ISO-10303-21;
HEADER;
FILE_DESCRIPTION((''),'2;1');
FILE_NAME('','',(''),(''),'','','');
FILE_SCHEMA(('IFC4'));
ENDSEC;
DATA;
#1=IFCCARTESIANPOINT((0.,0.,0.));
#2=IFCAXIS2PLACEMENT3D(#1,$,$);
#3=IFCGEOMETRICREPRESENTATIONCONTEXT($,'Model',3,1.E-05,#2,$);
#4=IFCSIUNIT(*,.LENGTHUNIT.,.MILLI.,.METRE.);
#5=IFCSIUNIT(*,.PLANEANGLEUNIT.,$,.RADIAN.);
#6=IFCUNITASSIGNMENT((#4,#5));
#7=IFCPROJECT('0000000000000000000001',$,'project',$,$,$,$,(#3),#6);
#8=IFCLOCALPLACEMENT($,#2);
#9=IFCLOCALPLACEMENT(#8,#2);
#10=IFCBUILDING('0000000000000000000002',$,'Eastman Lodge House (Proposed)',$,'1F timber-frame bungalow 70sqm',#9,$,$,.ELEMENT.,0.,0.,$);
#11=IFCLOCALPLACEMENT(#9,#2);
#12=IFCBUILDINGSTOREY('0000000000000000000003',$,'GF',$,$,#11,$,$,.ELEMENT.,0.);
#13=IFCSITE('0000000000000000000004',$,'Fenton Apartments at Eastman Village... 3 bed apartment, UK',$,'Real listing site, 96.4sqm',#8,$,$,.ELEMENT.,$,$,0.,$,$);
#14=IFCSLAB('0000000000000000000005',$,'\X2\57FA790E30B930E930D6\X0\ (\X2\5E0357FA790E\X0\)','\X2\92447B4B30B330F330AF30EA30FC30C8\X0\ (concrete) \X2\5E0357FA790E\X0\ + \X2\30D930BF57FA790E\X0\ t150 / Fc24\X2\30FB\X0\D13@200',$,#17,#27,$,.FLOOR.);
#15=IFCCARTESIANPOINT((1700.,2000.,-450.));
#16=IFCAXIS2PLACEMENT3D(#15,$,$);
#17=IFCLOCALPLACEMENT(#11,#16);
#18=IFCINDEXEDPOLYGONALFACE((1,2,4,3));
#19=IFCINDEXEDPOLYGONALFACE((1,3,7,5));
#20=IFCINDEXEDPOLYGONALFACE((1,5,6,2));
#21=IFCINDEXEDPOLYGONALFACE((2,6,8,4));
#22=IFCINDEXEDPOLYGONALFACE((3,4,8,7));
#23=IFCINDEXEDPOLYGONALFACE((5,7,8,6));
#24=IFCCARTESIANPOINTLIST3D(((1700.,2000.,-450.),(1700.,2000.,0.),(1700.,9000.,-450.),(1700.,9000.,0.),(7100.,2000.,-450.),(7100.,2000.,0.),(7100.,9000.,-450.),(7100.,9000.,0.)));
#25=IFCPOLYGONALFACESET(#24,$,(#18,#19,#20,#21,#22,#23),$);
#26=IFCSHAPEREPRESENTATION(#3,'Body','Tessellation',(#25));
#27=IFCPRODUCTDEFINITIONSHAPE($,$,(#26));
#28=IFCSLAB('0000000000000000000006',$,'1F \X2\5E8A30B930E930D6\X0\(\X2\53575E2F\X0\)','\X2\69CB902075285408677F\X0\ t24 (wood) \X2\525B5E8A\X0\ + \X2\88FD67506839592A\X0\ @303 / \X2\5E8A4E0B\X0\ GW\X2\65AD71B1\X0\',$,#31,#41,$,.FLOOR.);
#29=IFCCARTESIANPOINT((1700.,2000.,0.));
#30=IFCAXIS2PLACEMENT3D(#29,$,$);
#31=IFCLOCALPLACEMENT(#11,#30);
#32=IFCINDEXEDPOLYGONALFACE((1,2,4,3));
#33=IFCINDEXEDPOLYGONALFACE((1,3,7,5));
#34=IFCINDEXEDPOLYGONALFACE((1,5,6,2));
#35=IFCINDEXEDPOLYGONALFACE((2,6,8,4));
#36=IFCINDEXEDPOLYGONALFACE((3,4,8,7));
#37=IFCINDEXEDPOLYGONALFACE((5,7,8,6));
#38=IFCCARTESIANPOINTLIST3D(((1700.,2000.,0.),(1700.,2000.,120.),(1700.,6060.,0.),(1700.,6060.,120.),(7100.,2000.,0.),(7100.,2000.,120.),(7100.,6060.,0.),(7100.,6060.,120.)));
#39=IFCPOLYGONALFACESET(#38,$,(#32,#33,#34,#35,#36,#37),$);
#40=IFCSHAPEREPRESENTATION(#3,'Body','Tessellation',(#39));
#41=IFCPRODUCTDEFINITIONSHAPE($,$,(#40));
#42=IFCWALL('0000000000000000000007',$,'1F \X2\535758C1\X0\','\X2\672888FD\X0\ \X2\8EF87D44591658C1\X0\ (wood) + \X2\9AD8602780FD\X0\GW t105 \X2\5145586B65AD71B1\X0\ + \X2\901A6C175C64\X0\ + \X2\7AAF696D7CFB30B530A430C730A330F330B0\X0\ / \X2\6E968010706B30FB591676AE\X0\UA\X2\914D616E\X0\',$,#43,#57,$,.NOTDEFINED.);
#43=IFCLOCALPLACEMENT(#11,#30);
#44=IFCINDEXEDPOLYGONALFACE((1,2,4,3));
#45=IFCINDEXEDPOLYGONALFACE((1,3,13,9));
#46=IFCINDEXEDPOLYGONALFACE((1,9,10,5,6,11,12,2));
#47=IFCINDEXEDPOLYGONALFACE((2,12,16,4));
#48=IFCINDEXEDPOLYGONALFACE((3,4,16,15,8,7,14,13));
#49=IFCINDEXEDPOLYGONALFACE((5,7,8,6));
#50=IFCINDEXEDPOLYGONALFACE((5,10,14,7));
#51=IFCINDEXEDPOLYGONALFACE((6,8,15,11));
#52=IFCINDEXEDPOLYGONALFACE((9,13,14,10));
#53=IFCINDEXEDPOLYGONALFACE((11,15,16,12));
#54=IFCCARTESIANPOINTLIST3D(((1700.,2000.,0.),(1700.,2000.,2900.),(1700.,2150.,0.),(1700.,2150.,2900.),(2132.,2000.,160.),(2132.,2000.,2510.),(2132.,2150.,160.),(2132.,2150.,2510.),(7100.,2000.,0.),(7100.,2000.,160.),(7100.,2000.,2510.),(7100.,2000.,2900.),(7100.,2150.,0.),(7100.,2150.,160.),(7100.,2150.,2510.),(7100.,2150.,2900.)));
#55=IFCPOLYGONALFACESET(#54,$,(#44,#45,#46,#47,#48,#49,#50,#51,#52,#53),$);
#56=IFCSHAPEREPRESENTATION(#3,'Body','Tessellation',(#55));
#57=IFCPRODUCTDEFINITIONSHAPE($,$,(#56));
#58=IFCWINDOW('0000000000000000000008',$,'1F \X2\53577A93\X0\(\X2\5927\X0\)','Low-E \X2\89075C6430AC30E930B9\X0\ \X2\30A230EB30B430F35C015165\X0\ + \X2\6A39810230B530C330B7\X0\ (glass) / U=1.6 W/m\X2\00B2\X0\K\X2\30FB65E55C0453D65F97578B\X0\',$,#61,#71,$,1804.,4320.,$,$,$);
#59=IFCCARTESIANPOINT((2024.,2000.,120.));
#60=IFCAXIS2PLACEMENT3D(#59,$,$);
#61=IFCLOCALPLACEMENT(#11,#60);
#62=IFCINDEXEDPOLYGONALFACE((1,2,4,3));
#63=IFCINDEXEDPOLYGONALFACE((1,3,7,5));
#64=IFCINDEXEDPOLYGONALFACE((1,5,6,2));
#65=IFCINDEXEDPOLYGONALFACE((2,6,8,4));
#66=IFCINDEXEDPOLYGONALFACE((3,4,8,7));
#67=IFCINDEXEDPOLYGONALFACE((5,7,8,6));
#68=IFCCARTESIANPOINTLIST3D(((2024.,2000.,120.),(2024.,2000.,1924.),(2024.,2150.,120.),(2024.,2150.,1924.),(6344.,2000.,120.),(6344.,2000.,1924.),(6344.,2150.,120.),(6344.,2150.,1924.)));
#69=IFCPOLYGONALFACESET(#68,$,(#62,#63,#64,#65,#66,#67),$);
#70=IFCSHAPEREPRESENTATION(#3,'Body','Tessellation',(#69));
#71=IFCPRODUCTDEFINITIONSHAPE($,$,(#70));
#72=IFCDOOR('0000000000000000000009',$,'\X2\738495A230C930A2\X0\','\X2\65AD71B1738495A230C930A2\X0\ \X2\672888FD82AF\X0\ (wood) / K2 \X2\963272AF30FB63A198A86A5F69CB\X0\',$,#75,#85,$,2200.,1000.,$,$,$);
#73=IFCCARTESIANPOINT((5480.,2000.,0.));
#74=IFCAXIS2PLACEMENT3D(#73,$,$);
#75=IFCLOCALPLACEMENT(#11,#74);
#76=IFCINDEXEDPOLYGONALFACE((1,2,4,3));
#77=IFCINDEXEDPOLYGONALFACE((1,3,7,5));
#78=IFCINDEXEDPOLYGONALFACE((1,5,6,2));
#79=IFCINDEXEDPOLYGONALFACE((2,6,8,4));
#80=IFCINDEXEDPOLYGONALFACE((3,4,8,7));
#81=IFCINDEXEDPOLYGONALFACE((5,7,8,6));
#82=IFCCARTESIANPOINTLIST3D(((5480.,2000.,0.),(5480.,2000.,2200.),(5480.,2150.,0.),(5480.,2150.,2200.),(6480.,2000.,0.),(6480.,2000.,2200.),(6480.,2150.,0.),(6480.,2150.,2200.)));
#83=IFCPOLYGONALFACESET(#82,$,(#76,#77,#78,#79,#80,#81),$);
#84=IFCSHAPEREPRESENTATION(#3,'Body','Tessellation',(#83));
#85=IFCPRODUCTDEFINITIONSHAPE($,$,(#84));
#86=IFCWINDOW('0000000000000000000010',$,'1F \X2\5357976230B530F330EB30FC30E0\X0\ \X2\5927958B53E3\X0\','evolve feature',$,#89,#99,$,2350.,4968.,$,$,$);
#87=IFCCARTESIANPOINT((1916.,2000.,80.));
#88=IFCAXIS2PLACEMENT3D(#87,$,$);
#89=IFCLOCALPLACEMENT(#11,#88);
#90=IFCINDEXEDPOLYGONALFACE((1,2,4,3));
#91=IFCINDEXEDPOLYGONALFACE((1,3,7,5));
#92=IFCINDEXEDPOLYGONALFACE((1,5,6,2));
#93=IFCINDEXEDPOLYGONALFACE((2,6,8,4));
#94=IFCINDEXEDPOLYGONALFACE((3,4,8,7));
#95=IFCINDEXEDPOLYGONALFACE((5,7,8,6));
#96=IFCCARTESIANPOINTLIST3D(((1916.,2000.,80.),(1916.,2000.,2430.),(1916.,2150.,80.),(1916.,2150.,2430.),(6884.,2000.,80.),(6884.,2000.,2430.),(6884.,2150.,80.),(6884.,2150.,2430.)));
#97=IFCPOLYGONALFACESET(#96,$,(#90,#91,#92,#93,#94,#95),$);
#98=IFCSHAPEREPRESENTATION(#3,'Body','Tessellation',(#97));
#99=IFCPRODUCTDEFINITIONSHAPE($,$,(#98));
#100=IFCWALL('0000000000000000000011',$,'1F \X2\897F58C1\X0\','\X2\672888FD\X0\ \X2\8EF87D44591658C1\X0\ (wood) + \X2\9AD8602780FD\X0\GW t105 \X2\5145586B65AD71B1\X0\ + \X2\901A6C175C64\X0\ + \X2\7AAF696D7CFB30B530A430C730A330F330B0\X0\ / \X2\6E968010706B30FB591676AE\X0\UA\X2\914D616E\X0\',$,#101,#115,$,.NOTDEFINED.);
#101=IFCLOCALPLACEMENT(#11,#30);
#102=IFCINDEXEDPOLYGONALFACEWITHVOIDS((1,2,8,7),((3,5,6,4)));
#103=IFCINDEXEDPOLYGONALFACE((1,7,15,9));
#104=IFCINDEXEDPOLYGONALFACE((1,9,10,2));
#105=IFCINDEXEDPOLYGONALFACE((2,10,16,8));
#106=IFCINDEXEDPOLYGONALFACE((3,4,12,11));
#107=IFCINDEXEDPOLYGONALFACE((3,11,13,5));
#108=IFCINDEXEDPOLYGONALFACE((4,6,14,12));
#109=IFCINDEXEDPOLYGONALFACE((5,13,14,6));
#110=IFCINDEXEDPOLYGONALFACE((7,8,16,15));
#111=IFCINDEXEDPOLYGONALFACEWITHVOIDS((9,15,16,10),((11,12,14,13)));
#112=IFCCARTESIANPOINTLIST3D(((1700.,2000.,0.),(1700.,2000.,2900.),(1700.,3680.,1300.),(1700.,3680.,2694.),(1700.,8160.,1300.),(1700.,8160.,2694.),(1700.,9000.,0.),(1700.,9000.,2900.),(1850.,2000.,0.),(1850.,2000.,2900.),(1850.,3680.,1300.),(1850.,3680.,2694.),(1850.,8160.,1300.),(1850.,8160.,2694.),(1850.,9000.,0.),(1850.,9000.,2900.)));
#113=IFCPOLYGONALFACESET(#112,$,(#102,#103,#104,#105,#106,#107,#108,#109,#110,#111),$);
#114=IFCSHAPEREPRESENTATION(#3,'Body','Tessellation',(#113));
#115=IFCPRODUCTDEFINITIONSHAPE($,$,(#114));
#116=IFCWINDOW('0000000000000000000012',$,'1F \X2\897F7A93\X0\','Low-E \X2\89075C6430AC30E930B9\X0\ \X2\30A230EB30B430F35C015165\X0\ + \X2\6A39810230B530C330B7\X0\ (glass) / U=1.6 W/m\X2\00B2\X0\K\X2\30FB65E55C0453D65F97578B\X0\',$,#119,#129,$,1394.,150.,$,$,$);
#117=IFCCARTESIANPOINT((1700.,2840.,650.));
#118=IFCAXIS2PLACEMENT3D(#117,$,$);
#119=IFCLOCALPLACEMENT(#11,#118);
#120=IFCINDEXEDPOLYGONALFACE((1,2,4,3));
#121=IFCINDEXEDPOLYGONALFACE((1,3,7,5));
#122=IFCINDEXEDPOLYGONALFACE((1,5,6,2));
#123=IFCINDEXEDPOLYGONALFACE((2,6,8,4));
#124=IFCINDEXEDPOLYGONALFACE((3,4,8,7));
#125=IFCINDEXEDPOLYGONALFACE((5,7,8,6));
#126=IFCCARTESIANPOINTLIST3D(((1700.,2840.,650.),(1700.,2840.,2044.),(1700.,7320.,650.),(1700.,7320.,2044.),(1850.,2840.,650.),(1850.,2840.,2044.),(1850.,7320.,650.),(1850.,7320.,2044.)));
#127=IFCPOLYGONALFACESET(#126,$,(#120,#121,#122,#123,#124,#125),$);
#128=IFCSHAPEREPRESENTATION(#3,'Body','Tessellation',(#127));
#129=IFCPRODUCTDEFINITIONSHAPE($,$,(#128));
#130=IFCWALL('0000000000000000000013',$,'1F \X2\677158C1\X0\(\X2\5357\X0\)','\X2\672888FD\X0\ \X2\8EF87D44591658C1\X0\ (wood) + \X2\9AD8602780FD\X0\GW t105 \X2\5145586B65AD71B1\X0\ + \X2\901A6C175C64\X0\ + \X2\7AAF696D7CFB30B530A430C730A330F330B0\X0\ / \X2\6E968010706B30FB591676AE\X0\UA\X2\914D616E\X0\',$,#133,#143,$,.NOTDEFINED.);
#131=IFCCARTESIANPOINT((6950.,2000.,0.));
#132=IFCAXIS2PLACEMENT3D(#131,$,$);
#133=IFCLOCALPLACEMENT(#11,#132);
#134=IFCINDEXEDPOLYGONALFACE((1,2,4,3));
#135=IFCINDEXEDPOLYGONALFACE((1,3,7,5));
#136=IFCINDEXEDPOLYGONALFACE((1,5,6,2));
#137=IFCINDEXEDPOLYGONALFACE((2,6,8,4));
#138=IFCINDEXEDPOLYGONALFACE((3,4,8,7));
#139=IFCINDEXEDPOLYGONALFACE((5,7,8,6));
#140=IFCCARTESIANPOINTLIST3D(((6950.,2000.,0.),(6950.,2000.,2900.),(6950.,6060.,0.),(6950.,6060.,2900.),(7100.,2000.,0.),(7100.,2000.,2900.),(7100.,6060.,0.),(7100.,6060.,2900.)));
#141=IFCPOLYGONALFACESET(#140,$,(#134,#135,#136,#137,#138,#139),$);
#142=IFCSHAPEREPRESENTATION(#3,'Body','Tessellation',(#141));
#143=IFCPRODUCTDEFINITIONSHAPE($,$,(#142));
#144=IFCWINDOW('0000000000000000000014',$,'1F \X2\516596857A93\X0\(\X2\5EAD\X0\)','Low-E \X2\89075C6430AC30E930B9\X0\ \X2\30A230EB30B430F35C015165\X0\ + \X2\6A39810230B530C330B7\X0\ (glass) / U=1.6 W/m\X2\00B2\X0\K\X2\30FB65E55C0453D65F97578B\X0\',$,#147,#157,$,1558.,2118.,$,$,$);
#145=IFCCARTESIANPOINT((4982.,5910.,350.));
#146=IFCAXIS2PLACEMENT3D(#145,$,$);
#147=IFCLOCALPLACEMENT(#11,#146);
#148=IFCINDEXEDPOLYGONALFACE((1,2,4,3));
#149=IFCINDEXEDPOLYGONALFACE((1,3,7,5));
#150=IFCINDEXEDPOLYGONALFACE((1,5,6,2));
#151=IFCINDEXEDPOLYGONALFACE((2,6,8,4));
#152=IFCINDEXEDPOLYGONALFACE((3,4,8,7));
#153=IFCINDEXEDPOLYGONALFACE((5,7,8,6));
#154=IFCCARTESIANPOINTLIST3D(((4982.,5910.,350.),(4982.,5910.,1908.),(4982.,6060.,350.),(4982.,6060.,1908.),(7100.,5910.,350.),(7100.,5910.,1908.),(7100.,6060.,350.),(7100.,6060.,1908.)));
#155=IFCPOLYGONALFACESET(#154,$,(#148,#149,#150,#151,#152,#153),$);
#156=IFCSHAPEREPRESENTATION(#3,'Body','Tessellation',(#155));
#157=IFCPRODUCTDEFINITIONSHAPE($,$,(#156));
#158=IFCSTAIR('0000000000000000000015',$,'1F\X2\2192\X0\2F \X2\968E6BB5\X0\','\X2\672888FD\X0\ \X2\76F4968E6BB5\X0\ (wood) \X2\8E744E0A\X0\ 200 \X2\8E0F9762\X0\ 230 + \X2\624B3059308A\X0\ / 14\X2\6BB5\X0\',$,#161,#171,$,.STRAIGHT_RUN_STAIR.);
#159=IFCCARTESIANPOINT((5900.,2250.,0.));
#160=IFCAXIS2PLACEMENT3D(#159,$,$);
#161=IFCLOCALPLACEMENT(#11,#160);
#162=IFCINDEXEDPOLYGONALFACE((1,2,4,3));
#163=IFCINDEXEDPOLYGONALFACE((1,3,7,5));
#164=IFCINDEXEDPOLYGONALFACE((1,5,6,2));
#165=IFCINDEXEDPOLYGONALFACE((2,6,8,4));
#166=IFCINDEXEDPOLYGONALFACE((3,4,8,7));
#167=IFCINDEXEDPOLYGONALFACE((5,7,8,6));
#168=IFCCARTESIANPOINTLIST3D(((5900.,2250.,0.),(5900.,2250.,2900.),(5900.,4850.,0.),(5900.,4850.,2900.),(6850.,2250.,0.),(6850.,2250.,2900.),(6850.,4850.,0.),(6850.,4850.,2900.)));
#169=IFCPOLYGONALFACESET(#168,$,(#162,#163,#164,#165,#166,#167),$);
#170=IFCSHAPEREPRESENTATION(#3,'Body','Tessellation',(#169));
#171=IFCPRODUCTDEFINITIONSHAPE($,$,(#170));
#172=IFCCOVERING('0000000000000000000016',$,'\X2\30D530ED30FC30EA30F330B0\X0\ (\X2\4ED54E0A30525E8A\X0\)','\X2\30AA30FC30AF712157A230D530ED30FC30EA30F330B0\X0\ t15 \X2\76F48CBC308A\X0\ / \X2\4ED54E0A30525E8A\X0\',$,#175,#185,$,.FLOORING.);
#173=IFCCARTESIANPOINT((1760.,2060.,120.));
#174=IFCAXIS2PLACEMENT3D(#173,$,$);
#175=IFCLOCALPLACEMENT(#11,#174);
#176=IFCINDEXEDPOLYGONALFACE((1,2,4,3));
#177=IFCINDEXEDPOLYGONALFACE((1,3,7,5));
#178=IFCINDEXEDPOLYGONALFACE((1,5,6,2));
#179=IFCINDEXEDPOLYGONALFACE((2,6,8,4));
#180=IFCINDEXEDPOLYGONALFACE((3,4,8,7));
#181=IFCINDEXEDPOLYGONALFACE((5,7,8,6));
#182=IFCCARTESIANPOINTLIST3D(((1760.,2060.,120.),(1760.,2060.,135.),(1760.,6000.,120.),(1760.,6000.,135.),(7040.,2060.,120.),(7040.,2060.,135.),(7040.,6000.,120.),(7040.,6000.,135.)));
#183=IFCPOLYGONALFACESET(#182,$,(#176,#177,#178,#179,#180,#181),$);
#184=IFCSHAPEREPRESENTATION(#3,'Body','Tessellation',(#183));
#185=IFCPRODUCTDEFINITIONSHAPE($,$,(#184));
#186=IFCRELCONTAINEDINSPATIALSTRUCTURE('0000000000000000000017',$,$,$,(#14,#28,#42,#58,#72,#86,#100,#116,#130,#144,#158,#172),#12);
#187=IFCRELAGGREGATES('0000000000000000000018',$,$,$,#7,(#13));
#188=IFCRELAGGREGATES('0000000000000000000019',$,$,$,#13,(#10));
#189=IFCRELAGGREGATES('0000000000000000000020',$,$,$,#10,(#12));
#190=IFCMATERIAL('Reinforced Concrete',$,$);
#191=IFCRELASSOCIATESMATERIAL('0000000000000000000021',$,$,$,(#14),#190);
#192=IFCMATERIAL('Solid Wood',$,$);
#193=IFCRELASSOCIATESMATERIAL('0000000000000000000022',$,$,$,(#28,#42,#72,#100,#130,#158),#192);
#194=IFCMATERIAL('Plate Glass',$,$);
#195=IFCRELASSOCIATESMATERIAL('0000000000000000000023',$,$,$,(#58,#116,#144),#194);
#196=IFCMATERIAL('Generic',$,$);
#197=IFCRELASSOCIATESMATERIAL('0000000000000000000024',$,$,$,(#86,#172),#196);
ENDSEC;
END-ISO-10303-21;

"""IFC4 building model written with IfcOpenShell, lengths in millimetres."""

from ifc_helpers import new_model, si_unit, frame, frame_2d, origin, place, context, project, spatial, rectangle, extrude, material, element, fill, save


model = new_model("IFC4")

# Units and contexts
model_context = context("Model", 3, precision=1e-05, world=origin())
ifc_project = project(units=[si_unit("LENGTHUNIT", "METRE", prefix="MILLI"), si_unit("PLANEANGLEUNIT", "RADIAN")], contexts=[model_context])

# Site, building, storey
site_placement = place(None, origin())
site = spatial("IfcSite", under=ifc_project, at=site_placement, Name="Fenton Apartments at Eastman Village... 3 bed apartment, UK", ObjectType="Real listing site, 96.4sqm", CompositionType="ELEMENT", RefElevation=0.0)
building_placement = place(site_placement, origin())
building = spatial("IfcBuilding", under=site, at=building_placement, Name="Eastman Lodge House (Proposed)", ObjectType="1F timber-frame bungalow 70sqm", CompositionType="ELEMENT", ElevationOfRefHeight=0.0, ElevationOfTerrain=0.0)
storey_placement = place(building_placement, origin())
storey = spatial("IfcBuildingStorey", under=building, at=storey_placement, Name="GF", CompositionType="ELEMENT", Elevation=0.0)

# Slabs
ifc_material_1 = material(Name="Reinforced Concrete")
slab_1_placement = place(storey_placement, frame((1700.0, 2000.0, -450.0)))
element("IfcSlab", 1, at=slab_1_placement, inside=storey, material=ifc_material_1, Name="基礎スラブ (布基礎)", Description="鉄筋コンクリート (concrete) 布基礎 + ベタ基礎 t150 / Fc24・D13@200", PredefinedType="FLOOR", context=model_context, shape_type="SweptSolid", body=[
    extrude(rectangle(XDim=5400.0, YDim=7000.0, at=frame_2d((2700.0, 3500.0))), frame((1700.0, 2000.0, -450.0)), (0.0, 0.0, 1.0), 450.0),
])
ifc_material_2 = material(Name="Solid Wood")
slab_2_placement = place(storey_placement, frame((1700.0, 2000.0, 0.0)))
element("IfcSlab", 2, at=slab_2_placement, inside=storey, material=ifc_material_2, Name="1F 床スラブ(南帯)", Description="構造用合板 t24 (wood) 剛床 + 製材根太 @303 / 床下 GW断熱", PredefinedType="FLOOR", context=model_context, shape_type="SweptSolid", body=[
    extrude(rectangle(XDim=5400.0, YDim=4060.0, at=frame_2d((2700.0, 2030.0))), frame((1700.0, 2000.0, 0.0)), (0.0, 0.0, 1.0), 120.0),
])

# Wall, openings, windows, door
wall_1_placement = place(storey_placement, frame((1700.0, 2000.0, 0.0)))
wall_1 = element("IfcWall", 3, at=wall_1_placement, inside=storey, material=ifc_material_2, Name="1F 南壁", Description="木製 軸組外壁 (wood) + 高性能GW t105 充填断熱 + 通気層 + 窯業系サイディング / 準耐火・外皮UA配慮", PredefinedType="NOTDEFINED", context=model_context, shape_type="SweptSolid", body=[
    extrude(rectangle(XDim=5400.0, YDim=150.0, at=frame_2d((2700.0, 75.0))), frame((1700.0, 2000.0, 0.0)), (0.0, 0.0, 1.0), 2900.0),
])
opening_1_placement = place(storey_placement, frame((2024.0, 2000.0, 120.0)))
opening_1 = element("IfcOpeningElement", 4, at=opening_1_placement, cuts=wall_1, PredefinedType="NOTDEFINED", context=model_context, shape_type="SweptSolid", body=[
    extrude(rectangle(XDim=4320.0, YDim=150.0, at=frame_2d((2160.0, 75.0))), frame((2024.0, 2000.0, 120.0)), (0.0, 0.0, 1.0), 1804.0),
])
opening_2_placement = place(storey_placement, frame((5480.0, 2000.0, 0.0)))
opening_2 = element("IfcOpeningElement", 5, at=opening_2_placement, cuts=wall_1, PredefinedType="NOTDEFINED", context=model_context, shape_type="SweptSolid", body=[
    extrude(rectangle(XDim=1000.0, YDim=150.0, at=frame_2d((500.0, 75.0))), frame((5480.0, 2000.0, 0.0)), (0.0, 0.0, 1.0), 2200.0),
])
opening_3_placement = place(storey_placement, frame((1916.0, 2000.0, 80.0)))
opening_3 = element("IfcOpeningElement", 6, at=opening_3_placement, cuts=wall_1, PredefinedType="NOTDEFINED", context=model_context, shape_type="SweptSolid", body=[
    extrude(rectangle(XDim=4968.0, YDim=150.0, at=frame_2d((2484.0, 75.0))), frame((1916.0, 2000.0, 80.0)), (0.0, 0.0, 1.0), 2350.0),
])
ifc_material_3 = material(Name="Plate Glass")
window_1_placement = place(storey_placement, frame((2024.0, 2000.0, 120.0)))
window_1 = element("IfcWindow", 7, at=window_1_placement, inside=storey, material=ifc_material_3, Name="1F 南窓(大)", Description="Low-E 複層ガラス アルゴン封入 + 樹脂サッシ (glass) / U=1.6 W/m²K・日射取得型", OverallHeight=1804.0, OverallWidth=4320.0, context=model_context, shape_type="SweptSolid", body=[
    extrude(rectangle(XDim=4320.0, YDim=150.0, at=frame_2d((2160.0, 75.0))), frame((2024.0, 2000.0, 120.0)), (0.0, 0.0, 1.0), 1804.0),
])
fill(opening_1, window_1)
door_1_placement = place(storey_placement, frame((5480.0, 2000.0, 0.0)))
door_1 = element("IfcDoor", 8, at=door_1_placement, inside=storey, material=ifc_material_2, Name="玄関ドア", Description="断熱玄関ドア 木製芯 (wood) / K2 防犯・採風機構", OverallHeight=2200.0, OverallWidth=1000.0, context=model_context, shape_type="SweptSolid", body=[
    extrude(rectangle(XDim=1000.0, YDim=150.0, at=frame_2d((500.0, 75.0))), frame((5480.0, 2000.0, 0.0)), (0.0, 0.0, 1.0), 2200.0),
])
fill(opening_2, door_1)
ifc_material_4 = material(Name="Generic")
window_2_placement = place(storey_placement, frame((1916.0, 2000.0, 80.0)))
window_2 = element("IfcWindow", 9, at=window_2_placement, inside=storey, material=ifc_material_4, Name="1F 南面サンルーム 大開口", Description="evolve feature", OverallHeight=2350.0, OverallWidth=4968.0, context=model_context, shape_type="SweptSolid", body=[
    extrude(rectangle(XDim=4968.0, YDim=150.0, at=frame_2d((2484.0, 75.0))), frame((1916.0, 2000.0, 80.0)), (0.0, 0.0, 1.0), 2350.0),
])
fill(opening_3, window_2)

# Walls, openings, windows
wall_2_placement = place(storey_placement, frame((1700.0, 2000.0, 0.0)))
wall_2 = element("IfcWall", 10, at=wall_2_placement, inside=storey, material=ifc_material_2, Name="1F 西壁", Description="木製 軸組外壁 (wood) + 高性能GW t105 充填断熱 + 通気層 + 窯業系サイディング / 準耐火・外皮UA配慮", PredefinedType="NOTDEFINED", context=model_context, shape_type="SweptSolid", body=[
    extrude(rectangle(XDim=150.0, YDim=7000.0, at=frame_2d((75.0, 3500.0))), frame((1700.0, 2000.0, 0.0)), (0.0, 0.0, 1.0), 2900.0),
])
opening_4_placement = place(storey_placement, frame((1700.0, 2840.0, 650.0)))
opening_4 = element("IfcOpeningElement", 11, at=opening_4_placement, cuts=wall_2, PredefinedType="NOTDEFINED", context=model_context, shape_type="SweptSolid", body=[
    extrude(rectangle(XDim=150.0, YDim=4480.0, at=frame_2d((75.0, 2240.0))), frame((1700.0, 2840.0, 650.0)), (0.0, 0.0, 1.0), 1394.0),
])
window_3_placement = place(storey_placement, frame((1700.0, 2840.0, 650.0)))
window_3 = element("IfcWindow", 12, at=window_3_placement, inside=storey, material=ifc_material_3, Name="1F 西窓", Description="Low-E 複層ガラス アルゴン封入 + 樹脂サッシ (glass) / U=1.6 W/m²K・日射取得型", OverallHeight=1394.0, OverallWidth=150.0, context=model_context, shape_type="SweptSolid", body=[
    extrude(rectangle(XDim=150.0, YDim=4480.0, at=frame_2d((75.0, 2240.0))), frame((1700.0, 2840.0, 650.0)), (0.0, 0.0, 1.0), 1394.0),
])
fill(opening_4, window_3)
wall_3_placement = place(storey_placement, frame((6950.0, 2000.0, 0.0)))
wall_3 = element("IfcWall", 13, at=wall_3_placement, inside=storey, material=ifc_material_2, Name="1F 東壁(南)", Description="木製 軸組外壁 (wood) + 高性能GW t105 充填断熱 + 通気層 + 窯業系サイディング / 準耐火・外皮UA配慮", PredefinedType="NOTDEFINED", context=model_context, shape_type="SweptSolid", body=[
    extrude(rectangle(XDim=150.0, YDim=4060.0, at=frame_2d((75.0, 2030.0))), frame((6950.0, 2000.0, 0.0)), (0.0, 0.0, 1.0), 2900.0),
])
opening_5_placement = place(storey_placement, frame((4982.0, 5910.0, 350.0)))
opening_5 = element("IfcOpeningElement", 14, at=opening_5_placement, cuts=wall_3, PredefinedType="NOTDEFINED", context=model_context, shape_type="SweptSolid", body=[
    extrude(rectangle(XDim=2118.0, YDim=150.0, at=frame_2d((1059.0, 75.0))), frame((4982.0, 5910.0, 350.0)), (0.0, 0.0, 1.0), 1558.0),
])
window_4_placement = place(storey_placement, frame((4982.0, 5910.0, 350.0)))
window_4 = element("IfcWindow", 15, at=window_4_placement, inside=storey, material=ifc_material_3, Name="1F 入隅窓(庭)", Description="Low-E 複層ガラス アルゴン封入 + 樹脂サッシ (glass) / U=1.6 W/m²K・日射取得型", OverallHeight=1558.0, OverallWidth=2118.0, context=model_context, shape_type="SweptSolid", body=[
    extrude(rectangle(XDim=2118.0, YDim=150.0, at=frame_2d((1059.0, 75.0))), frame((4982.0, 5910.0, 350.0)), (0.0, 0.0, 1.0), 1558.0),
])
fill(opening_5, window_4)

# Stair
stair_placement = place(storey_placement, frame((5900.0, 2250.0, 0.0)))
element("IfcStair", 16, at=stair_placement, inside=storey, material=ifc_material_2, Name="1F→2F 階段", Description="木製 直階段 (wood) 蹴上 200 踏面 230 + 手すり / 14段", PredefinedType="STRAIGHT_RUN_STAIR", context=model_context, shape_type="SweptSolid", body=[
    extrude(rectangle(XDim=950.0, YDim=2600.0, at=frame_2d((475.0, 1300.0))), frame((5900.0, 2250.0, 0.0)), (0.0, 0.0, 1.0), 2900.0),
])

# Covering
covering_placement = place(storey_placement, frame((1760.0, 2060.0, 120.0)))
element("IfcCovering", 17, at=covering_placement, inside=storey, material=ifc_material_4, Name="フローリング (仕上げ床)", Description="オーク無垢フローリング t15 直貼り / 仕上げ床", PredefinedType="FLOORING", context=model_context, shape_type="SweptSolid", body=[
    extrude(rectangle(XDim=5280.0, YDim=3940.0, at=frame_2d((2640.0, 1970.0))), frame((1760.0, 2060.0, 120.0)), (0.0, 0.0, 1.0), 15.0),
])

save(model, "model.ifc")
